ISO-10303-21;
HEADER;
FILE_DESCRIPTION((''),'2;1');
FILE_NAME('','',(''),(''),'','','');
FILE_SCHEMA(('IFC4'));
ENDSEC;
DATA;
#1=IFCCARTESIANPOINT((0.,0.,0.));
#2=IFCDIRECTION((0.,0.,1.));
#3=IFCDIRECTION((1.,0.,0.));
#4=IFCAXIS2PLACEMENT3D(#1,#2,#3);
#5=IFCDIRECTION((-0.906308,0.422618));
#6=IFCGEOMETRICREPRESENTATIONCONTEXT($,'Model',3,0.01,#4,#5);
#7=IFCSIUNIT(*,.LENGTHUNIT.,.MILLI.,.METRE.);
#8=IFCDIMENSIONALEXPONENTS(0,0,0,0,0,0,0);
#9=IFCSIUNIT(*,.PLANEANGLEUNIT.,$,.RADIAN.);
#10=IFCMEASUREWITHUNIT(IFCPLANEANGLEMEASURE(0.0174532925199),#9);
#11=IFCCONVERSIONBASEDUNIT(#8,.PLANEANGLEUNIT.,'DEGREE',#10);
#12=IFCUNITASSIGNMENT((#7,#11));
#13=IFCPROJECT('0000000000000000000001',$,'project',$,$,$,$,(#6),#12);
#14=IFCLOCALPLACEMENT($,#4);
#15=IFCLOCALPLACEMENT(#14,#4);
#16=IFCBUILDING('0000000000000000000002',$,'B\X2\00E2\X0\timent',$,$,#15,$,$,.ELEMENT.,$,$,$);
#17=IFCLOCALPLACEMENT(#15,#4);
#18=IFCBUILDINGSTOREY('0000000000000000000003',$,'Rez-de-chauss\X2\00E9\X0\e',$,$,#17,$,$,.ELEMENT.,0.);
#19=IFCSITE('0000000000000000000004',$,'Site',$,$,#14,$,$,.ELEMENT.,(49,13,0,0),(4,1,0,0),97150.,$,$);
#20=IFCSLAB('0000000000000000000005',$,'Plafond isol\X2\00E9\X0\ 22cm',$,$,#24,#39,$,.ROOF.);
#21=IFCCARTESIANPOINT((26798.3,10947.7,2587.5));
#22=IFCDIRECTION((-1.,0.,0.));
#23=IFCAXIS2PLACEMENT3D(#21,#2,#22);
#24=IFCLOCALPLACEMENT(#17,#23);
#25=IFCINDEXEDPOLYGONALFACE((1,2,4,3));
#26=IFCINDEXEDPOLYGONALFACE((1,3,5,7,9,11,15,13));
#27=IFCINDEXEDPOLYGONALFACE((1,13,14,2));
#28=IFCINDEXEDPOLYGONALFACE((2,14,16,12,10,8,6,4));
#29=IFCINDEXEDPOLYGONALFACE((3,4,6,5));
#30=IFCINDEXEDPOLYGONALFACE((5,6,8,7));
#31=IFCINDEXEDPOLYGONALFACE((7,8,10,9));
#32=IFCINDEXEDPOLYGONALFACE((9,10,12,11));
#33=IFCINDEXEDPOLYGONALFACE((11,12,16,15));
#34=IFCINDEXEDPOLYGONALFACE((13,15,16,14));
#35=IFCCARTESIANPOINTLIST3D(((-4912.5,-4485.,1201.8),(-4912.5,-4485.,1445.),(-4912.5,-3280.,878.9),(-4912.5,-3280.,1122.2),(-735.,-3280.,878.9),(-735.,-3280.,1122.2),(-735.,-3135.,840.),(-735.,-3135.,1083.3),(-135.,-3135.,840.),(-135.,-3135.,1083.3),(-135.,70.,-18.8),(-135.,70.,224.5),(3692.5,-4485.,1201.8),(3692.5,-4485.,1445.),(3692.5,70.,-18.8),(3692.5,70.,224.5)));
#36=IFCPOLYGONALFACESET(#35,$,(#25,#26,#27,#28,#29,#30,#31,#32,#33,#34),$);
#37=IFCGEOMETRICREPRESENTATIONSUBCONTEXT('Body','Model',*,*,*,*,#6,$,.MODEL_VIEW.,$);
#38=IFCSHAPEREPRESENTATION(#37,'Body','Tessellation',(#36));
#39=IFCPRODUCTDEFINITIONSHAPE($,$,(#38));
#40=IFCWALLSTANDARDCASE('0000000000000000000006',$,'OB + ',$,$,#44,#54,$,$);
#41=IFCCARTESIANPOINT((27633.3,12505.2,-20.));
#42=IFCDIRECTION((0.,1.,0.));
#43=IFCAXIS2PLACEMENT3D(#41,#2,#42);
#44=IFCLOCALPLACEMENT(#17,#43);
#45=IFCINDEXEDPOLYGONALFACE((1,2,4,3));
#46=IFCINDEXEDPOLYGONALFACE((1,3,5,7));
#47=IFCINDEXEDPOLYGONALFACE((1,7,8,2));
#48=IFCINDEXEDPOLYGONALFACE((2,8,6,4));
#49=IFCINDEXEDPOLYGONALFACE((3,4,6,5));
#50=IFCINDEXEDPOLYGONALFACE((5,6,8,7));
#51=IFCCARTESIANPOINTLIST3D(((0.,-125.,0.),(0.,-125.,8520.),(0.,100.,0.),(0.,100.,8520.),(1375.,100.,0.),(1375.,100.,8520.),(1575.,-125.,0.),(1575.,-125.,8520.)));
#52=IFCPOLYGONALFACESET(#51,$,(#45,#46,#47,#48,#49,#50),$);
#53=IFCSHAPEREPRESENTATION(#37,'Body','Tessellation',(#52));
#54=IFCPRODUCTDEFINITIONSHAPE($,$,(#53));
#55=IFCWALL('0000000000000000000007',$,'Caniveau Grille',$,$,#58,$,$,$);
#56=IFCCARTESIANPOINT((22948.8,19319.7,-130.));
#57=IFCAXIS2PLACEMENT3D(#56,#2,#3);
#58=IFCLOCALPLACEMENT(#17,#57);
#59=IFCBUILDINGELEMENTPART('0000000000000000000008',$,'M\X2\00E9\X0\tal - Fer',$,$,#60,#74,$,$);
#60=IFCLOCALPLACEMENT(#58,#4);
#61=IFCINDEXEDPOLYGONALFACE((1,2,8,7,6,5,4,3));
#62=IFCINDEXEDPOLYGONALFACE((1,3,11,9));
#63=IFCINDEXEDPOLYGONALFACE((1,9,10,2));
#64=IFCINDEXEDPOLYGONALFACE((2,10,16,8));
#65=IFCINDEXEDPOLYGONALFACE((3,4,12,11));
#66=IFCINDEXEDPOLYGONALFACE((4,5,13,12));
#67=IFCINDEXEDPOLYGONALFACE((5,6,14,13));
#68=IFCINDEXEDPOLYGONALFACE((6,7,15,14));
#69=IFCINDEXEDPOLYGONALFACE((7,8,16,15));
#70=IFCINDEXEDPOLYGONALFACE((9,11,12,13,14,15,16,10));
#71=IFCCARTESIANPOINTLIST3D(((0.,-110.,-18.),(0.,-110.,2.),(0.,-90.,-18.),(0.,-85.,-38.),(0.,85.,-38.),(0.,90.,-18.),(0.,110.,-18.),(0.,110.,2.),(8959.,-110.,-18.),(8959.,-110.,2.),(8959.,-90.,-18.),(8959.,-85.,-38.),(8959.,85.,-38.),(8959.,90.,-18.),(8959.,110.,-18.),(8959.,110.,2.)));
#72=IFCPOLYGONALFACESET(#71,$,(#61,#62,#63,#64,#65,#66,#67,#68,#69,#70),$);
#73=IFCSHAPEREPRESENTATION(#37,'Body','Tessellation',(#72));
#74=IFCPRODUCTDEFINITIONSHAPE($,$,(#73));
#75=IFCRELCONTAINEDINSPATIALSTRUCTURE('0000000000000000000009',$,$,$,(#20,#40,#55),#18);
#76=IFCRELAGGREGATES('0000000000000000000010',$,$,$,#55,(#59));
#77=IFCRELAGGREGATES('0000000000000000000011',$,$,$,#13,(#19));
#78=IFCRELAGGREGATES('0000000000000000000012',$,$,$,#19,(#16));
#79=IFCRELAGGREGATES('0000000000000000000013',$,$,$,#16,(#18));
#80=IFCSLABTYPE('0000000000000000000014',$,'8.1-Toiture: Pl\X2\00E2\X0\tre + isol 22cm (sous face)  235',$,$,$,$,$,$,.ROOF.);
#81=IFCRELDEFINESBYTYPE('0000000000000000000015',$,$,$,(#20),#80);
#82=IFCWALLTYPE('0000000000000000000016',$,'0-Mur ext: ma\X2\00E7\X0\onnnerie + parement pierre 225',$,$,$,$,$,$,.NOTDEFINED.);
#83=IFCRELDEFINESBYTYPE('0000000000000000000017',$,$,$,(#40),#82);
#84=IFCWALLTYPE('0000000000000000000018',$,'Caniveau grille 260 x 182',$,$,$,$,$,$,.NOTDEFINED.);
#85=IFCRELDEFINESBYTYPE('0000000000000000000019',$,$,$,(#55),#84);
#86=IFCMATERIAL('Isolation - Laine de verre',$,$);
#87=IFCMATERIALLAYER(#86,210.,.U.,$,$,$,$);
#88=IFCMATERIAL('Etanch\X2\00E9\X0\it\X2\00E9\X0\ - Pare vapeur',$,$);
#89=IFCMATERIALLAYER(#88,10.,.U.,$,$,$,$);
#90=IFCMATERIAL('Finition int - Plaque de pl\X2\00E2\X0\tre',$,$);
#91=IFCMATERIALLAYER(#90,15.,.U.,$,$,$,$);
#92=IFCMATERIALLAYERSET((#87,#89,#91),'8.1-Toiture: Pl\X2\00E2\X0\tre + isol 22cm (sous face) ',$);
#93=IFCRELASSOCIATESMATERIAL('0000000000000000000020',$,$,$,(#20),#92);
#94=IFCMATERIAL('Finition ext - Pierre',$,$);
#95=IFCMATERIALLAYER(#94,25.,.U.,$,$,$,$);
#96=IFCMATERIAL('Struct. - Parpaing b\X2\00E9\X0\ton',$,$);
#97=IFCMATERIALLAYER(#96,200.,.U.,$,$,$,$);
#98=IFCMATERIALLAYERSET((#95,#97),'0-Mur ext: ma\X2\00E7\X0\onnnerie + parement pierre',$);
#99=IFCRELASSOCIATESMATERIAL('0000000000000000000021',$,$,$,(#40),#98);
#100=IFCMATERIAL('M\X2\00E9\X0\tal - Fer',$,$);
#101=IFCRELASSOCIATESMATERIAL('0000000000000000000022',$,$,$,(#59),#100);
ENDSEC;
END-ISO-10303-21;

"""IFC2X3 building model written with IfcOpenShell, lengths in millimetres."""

from ifc_helpers import new_model, entity, si_unit, converted_unit, direction, frame, origin_with_axes, place, context, subcontext, project, spatial, polyline, outline, extrude, material, layer, layer_set, layer_usage, type_object, element, aggregate, save


model = new_model("IFC2X3")

# Units and contexts
model_context = context("Model", 3, precision=0.01, world=origin_with_axes(), true_north=direction((-0.906308, 0.422618)))
body_context = subcontext(model_context, "Body", "Model", "MODEL_VIEW")
ifc_project = project(units=[si_unit("LENGTHUNIT", "METRE", prefix="MILLI"), converted_unit("PLANEANGLEUNIT", "DEGREE", entity("IfcPlaneAngleMeasure", 0.0174532925199), si_unit("PLANEANGLEUNIT", "RADIAN"), dimensions=[0, 0, 0, 0, 0, 0, 0])], contexts=[model_context])

# Site, building, storey
site_placement = place(None, origin_with_axes())
site = spatial("IfcSite", under=ifc_project, at=site_placement, Name="Site", CompositionType="ELEMENT", RefLatitude=(49, 13, 0, 0), RefLongitude=(4, 1, 0, 0), RefElevation=97150.0)
building_placement = place(site_placement, origin_with_axes())
building = spatial("IfcBuilding", under=site, at=building_placement, Name="Bâtiment", CompositionType="ELEMENT")
storey_placement = place(building_placement, origin_with_axes())
storey = spatial("IfcBuildingStorey", under=building, at=storey_placement, Name="Rez-de-chaussée", CompositionType="ELEMENT", Elevation=0.0)

# Slab
ifc_material_1 = material(Name="Isolation - Laine de verre")
ifc_layer_1 = layer(ifc_material_1, 210.0, ventilated="UNKNOWN")
ifc_material_2 = material(Name="Etanchéité - Pare vapeur")
ifc_layer_2 = layer(ifc_material_2, 10.0, ventilated="UNKNOWN")
ifc_material_3 = material(Name="Finition int - Plaque de plâtre")
ifc_layer_3 = layer(ifc_material_3, 15.0, ventilated="UNKNOWN")
ifc_layer_set_1 = layer_set([ifc_layer_1, ifc_layer_2, ifc_layer_3], Name="8.1-Toiture: Plâtre + isol 22cm (sous face) ")
ifc_layer_usage_1 = layer_usage(ifc_layer_set_1, "AXIS3", "NEGATIVE", 235.0)
slab_type_1 = type_object("IfcSlabType", Name="8.1-Toiture: Plâtre + isol 22cm (sous face)  235", PredefinedType="ROOF")
slab_1_placement = place(storey_placement, frame((26798.3, 10947.7, 2587.5), z_axis=(0.0, 0.0, 1.0), x_axis=(-1.0, 0.0, 0.0)))
element("IfcSlab", 1, at=slab_1_placement, inside=storey, type_object=slab_type_1, material=ifc_layer_usage_1, Name="Plafond isolé 22cm", PredefinedType="ROOF", context=body_context, shape_type="SweptSolid", body=[
    extrude(outline(polyline([(-135.0, 72.5), (-135.0, -3245.6), (-735.0, -3245.6), (-735.0, -3395.7), (-4912.5, -3395.7), (-4912.5, -4643.2), (3692.5, -4643.2), (3692.5, 72.5), (-135.0, 72.5)])), frame((0.0, 0.0, 0.0), z_axis=(0.0, 0.258819, 0.965926), x_axis=(1.0, 0.0, 0.0)), (0.0, -0.258819, 0.965926), 243.3),
])

# Wall
ifc_material_4 = material(Name="Struct. - Parpaing béton")
ifc_material_5 = material(Name="Finition ext - Pierre")
ifc_layer_4 = layer(ifc_material_5, 25.0, ventilated="UNKNOWN")
ifc_layer_5 = layer(ifc_material_4, 200.0, ventilated="UNKNOWN")
ifc_layer_set_2 = layer_set([ifc_layer_4, ifc_layer_5], Name="0-Mur ext: maçonnnerie + parement pierre")
ifc_layer_usage_2 = layer_usage(ifc_layer_set_2, "AXIS2", "POSITIVE", -125.0)
wall_type_1 = type_object("IfcWallType", Name="0-Mur ext: maçonnnerie + parement pierre 225", PredefinedType="NOTDEFINED")
wall_1_placement = place(storey_placement, frame((27633.3, 12505.2, -20.0), z_axis=(0.0, 0.0, 1.0), x_axis=(0.0, 1.0, 0.0)))
element("IfcWallStandardCase", 2, at=wall_1_placement, inside=storey, type_object=wall_type_1, material=ifc_layer_usage_2, Name="OB + ", context=body_context, shape_type="SweptSolid", body=[
    extrude(outline(polyline([(0.0, -125.0), (1575.0, -125.0), (1375.0, 100.0), (0.0, 100.0), (0.0, -125.0)])), origin_with_axes(), (0.0, 0.0, 1.0), 8520.0),
])

# Wall, building element part
wall_type_2 = type_object("IfcWallType", Name="Caniveau grille 260 x 182", PredefinedType="NOTDEFINED")
wall_2_placement = place(storey_placement, frame((22948.8, 19319.7, -130.0), z_axis=(0.0, 0.0, 1.0), x_axis=(1.0, 0.0, 0.0)))
wall_2 = element("IfcWall", 3, at=wall_2_placement, inside=storey, type_object=wall_type_2, Name="Caniveau Grille")
ifc_material_6 = material(Name="Métal - Fer")
building_element_part_1_placement = place(wall_2_placement, origin_with_axes())
building_element_part_1 = element("IfcBuildingElementPart", 4, at=building_element_part_1_placement, material=ifc_material_6, Name="Métal - Fer", context=body_context, shape_type="SweptSolid", body=[
    extrude(outline(polyline([(-110.0, 2.0), (-110.0, -18.0), (-90.0, -18.0), (-85.0, -38.0), (85.0, -38.0), (90.0, -18.0), (110.0, -18.0), (110.0, 2.0), (-110.0, 2.0)])), frame((0.0, 0.0, 0.0), z_axis=(-1.0, 0.0, 0.0), x_axis=(0.0, -1.0, 0.0)), (0.0, 0.0, -1.0), 8959.0),
])
aggregate(wall_2, [building_element_part_1])

save(model, "model.ifc")
